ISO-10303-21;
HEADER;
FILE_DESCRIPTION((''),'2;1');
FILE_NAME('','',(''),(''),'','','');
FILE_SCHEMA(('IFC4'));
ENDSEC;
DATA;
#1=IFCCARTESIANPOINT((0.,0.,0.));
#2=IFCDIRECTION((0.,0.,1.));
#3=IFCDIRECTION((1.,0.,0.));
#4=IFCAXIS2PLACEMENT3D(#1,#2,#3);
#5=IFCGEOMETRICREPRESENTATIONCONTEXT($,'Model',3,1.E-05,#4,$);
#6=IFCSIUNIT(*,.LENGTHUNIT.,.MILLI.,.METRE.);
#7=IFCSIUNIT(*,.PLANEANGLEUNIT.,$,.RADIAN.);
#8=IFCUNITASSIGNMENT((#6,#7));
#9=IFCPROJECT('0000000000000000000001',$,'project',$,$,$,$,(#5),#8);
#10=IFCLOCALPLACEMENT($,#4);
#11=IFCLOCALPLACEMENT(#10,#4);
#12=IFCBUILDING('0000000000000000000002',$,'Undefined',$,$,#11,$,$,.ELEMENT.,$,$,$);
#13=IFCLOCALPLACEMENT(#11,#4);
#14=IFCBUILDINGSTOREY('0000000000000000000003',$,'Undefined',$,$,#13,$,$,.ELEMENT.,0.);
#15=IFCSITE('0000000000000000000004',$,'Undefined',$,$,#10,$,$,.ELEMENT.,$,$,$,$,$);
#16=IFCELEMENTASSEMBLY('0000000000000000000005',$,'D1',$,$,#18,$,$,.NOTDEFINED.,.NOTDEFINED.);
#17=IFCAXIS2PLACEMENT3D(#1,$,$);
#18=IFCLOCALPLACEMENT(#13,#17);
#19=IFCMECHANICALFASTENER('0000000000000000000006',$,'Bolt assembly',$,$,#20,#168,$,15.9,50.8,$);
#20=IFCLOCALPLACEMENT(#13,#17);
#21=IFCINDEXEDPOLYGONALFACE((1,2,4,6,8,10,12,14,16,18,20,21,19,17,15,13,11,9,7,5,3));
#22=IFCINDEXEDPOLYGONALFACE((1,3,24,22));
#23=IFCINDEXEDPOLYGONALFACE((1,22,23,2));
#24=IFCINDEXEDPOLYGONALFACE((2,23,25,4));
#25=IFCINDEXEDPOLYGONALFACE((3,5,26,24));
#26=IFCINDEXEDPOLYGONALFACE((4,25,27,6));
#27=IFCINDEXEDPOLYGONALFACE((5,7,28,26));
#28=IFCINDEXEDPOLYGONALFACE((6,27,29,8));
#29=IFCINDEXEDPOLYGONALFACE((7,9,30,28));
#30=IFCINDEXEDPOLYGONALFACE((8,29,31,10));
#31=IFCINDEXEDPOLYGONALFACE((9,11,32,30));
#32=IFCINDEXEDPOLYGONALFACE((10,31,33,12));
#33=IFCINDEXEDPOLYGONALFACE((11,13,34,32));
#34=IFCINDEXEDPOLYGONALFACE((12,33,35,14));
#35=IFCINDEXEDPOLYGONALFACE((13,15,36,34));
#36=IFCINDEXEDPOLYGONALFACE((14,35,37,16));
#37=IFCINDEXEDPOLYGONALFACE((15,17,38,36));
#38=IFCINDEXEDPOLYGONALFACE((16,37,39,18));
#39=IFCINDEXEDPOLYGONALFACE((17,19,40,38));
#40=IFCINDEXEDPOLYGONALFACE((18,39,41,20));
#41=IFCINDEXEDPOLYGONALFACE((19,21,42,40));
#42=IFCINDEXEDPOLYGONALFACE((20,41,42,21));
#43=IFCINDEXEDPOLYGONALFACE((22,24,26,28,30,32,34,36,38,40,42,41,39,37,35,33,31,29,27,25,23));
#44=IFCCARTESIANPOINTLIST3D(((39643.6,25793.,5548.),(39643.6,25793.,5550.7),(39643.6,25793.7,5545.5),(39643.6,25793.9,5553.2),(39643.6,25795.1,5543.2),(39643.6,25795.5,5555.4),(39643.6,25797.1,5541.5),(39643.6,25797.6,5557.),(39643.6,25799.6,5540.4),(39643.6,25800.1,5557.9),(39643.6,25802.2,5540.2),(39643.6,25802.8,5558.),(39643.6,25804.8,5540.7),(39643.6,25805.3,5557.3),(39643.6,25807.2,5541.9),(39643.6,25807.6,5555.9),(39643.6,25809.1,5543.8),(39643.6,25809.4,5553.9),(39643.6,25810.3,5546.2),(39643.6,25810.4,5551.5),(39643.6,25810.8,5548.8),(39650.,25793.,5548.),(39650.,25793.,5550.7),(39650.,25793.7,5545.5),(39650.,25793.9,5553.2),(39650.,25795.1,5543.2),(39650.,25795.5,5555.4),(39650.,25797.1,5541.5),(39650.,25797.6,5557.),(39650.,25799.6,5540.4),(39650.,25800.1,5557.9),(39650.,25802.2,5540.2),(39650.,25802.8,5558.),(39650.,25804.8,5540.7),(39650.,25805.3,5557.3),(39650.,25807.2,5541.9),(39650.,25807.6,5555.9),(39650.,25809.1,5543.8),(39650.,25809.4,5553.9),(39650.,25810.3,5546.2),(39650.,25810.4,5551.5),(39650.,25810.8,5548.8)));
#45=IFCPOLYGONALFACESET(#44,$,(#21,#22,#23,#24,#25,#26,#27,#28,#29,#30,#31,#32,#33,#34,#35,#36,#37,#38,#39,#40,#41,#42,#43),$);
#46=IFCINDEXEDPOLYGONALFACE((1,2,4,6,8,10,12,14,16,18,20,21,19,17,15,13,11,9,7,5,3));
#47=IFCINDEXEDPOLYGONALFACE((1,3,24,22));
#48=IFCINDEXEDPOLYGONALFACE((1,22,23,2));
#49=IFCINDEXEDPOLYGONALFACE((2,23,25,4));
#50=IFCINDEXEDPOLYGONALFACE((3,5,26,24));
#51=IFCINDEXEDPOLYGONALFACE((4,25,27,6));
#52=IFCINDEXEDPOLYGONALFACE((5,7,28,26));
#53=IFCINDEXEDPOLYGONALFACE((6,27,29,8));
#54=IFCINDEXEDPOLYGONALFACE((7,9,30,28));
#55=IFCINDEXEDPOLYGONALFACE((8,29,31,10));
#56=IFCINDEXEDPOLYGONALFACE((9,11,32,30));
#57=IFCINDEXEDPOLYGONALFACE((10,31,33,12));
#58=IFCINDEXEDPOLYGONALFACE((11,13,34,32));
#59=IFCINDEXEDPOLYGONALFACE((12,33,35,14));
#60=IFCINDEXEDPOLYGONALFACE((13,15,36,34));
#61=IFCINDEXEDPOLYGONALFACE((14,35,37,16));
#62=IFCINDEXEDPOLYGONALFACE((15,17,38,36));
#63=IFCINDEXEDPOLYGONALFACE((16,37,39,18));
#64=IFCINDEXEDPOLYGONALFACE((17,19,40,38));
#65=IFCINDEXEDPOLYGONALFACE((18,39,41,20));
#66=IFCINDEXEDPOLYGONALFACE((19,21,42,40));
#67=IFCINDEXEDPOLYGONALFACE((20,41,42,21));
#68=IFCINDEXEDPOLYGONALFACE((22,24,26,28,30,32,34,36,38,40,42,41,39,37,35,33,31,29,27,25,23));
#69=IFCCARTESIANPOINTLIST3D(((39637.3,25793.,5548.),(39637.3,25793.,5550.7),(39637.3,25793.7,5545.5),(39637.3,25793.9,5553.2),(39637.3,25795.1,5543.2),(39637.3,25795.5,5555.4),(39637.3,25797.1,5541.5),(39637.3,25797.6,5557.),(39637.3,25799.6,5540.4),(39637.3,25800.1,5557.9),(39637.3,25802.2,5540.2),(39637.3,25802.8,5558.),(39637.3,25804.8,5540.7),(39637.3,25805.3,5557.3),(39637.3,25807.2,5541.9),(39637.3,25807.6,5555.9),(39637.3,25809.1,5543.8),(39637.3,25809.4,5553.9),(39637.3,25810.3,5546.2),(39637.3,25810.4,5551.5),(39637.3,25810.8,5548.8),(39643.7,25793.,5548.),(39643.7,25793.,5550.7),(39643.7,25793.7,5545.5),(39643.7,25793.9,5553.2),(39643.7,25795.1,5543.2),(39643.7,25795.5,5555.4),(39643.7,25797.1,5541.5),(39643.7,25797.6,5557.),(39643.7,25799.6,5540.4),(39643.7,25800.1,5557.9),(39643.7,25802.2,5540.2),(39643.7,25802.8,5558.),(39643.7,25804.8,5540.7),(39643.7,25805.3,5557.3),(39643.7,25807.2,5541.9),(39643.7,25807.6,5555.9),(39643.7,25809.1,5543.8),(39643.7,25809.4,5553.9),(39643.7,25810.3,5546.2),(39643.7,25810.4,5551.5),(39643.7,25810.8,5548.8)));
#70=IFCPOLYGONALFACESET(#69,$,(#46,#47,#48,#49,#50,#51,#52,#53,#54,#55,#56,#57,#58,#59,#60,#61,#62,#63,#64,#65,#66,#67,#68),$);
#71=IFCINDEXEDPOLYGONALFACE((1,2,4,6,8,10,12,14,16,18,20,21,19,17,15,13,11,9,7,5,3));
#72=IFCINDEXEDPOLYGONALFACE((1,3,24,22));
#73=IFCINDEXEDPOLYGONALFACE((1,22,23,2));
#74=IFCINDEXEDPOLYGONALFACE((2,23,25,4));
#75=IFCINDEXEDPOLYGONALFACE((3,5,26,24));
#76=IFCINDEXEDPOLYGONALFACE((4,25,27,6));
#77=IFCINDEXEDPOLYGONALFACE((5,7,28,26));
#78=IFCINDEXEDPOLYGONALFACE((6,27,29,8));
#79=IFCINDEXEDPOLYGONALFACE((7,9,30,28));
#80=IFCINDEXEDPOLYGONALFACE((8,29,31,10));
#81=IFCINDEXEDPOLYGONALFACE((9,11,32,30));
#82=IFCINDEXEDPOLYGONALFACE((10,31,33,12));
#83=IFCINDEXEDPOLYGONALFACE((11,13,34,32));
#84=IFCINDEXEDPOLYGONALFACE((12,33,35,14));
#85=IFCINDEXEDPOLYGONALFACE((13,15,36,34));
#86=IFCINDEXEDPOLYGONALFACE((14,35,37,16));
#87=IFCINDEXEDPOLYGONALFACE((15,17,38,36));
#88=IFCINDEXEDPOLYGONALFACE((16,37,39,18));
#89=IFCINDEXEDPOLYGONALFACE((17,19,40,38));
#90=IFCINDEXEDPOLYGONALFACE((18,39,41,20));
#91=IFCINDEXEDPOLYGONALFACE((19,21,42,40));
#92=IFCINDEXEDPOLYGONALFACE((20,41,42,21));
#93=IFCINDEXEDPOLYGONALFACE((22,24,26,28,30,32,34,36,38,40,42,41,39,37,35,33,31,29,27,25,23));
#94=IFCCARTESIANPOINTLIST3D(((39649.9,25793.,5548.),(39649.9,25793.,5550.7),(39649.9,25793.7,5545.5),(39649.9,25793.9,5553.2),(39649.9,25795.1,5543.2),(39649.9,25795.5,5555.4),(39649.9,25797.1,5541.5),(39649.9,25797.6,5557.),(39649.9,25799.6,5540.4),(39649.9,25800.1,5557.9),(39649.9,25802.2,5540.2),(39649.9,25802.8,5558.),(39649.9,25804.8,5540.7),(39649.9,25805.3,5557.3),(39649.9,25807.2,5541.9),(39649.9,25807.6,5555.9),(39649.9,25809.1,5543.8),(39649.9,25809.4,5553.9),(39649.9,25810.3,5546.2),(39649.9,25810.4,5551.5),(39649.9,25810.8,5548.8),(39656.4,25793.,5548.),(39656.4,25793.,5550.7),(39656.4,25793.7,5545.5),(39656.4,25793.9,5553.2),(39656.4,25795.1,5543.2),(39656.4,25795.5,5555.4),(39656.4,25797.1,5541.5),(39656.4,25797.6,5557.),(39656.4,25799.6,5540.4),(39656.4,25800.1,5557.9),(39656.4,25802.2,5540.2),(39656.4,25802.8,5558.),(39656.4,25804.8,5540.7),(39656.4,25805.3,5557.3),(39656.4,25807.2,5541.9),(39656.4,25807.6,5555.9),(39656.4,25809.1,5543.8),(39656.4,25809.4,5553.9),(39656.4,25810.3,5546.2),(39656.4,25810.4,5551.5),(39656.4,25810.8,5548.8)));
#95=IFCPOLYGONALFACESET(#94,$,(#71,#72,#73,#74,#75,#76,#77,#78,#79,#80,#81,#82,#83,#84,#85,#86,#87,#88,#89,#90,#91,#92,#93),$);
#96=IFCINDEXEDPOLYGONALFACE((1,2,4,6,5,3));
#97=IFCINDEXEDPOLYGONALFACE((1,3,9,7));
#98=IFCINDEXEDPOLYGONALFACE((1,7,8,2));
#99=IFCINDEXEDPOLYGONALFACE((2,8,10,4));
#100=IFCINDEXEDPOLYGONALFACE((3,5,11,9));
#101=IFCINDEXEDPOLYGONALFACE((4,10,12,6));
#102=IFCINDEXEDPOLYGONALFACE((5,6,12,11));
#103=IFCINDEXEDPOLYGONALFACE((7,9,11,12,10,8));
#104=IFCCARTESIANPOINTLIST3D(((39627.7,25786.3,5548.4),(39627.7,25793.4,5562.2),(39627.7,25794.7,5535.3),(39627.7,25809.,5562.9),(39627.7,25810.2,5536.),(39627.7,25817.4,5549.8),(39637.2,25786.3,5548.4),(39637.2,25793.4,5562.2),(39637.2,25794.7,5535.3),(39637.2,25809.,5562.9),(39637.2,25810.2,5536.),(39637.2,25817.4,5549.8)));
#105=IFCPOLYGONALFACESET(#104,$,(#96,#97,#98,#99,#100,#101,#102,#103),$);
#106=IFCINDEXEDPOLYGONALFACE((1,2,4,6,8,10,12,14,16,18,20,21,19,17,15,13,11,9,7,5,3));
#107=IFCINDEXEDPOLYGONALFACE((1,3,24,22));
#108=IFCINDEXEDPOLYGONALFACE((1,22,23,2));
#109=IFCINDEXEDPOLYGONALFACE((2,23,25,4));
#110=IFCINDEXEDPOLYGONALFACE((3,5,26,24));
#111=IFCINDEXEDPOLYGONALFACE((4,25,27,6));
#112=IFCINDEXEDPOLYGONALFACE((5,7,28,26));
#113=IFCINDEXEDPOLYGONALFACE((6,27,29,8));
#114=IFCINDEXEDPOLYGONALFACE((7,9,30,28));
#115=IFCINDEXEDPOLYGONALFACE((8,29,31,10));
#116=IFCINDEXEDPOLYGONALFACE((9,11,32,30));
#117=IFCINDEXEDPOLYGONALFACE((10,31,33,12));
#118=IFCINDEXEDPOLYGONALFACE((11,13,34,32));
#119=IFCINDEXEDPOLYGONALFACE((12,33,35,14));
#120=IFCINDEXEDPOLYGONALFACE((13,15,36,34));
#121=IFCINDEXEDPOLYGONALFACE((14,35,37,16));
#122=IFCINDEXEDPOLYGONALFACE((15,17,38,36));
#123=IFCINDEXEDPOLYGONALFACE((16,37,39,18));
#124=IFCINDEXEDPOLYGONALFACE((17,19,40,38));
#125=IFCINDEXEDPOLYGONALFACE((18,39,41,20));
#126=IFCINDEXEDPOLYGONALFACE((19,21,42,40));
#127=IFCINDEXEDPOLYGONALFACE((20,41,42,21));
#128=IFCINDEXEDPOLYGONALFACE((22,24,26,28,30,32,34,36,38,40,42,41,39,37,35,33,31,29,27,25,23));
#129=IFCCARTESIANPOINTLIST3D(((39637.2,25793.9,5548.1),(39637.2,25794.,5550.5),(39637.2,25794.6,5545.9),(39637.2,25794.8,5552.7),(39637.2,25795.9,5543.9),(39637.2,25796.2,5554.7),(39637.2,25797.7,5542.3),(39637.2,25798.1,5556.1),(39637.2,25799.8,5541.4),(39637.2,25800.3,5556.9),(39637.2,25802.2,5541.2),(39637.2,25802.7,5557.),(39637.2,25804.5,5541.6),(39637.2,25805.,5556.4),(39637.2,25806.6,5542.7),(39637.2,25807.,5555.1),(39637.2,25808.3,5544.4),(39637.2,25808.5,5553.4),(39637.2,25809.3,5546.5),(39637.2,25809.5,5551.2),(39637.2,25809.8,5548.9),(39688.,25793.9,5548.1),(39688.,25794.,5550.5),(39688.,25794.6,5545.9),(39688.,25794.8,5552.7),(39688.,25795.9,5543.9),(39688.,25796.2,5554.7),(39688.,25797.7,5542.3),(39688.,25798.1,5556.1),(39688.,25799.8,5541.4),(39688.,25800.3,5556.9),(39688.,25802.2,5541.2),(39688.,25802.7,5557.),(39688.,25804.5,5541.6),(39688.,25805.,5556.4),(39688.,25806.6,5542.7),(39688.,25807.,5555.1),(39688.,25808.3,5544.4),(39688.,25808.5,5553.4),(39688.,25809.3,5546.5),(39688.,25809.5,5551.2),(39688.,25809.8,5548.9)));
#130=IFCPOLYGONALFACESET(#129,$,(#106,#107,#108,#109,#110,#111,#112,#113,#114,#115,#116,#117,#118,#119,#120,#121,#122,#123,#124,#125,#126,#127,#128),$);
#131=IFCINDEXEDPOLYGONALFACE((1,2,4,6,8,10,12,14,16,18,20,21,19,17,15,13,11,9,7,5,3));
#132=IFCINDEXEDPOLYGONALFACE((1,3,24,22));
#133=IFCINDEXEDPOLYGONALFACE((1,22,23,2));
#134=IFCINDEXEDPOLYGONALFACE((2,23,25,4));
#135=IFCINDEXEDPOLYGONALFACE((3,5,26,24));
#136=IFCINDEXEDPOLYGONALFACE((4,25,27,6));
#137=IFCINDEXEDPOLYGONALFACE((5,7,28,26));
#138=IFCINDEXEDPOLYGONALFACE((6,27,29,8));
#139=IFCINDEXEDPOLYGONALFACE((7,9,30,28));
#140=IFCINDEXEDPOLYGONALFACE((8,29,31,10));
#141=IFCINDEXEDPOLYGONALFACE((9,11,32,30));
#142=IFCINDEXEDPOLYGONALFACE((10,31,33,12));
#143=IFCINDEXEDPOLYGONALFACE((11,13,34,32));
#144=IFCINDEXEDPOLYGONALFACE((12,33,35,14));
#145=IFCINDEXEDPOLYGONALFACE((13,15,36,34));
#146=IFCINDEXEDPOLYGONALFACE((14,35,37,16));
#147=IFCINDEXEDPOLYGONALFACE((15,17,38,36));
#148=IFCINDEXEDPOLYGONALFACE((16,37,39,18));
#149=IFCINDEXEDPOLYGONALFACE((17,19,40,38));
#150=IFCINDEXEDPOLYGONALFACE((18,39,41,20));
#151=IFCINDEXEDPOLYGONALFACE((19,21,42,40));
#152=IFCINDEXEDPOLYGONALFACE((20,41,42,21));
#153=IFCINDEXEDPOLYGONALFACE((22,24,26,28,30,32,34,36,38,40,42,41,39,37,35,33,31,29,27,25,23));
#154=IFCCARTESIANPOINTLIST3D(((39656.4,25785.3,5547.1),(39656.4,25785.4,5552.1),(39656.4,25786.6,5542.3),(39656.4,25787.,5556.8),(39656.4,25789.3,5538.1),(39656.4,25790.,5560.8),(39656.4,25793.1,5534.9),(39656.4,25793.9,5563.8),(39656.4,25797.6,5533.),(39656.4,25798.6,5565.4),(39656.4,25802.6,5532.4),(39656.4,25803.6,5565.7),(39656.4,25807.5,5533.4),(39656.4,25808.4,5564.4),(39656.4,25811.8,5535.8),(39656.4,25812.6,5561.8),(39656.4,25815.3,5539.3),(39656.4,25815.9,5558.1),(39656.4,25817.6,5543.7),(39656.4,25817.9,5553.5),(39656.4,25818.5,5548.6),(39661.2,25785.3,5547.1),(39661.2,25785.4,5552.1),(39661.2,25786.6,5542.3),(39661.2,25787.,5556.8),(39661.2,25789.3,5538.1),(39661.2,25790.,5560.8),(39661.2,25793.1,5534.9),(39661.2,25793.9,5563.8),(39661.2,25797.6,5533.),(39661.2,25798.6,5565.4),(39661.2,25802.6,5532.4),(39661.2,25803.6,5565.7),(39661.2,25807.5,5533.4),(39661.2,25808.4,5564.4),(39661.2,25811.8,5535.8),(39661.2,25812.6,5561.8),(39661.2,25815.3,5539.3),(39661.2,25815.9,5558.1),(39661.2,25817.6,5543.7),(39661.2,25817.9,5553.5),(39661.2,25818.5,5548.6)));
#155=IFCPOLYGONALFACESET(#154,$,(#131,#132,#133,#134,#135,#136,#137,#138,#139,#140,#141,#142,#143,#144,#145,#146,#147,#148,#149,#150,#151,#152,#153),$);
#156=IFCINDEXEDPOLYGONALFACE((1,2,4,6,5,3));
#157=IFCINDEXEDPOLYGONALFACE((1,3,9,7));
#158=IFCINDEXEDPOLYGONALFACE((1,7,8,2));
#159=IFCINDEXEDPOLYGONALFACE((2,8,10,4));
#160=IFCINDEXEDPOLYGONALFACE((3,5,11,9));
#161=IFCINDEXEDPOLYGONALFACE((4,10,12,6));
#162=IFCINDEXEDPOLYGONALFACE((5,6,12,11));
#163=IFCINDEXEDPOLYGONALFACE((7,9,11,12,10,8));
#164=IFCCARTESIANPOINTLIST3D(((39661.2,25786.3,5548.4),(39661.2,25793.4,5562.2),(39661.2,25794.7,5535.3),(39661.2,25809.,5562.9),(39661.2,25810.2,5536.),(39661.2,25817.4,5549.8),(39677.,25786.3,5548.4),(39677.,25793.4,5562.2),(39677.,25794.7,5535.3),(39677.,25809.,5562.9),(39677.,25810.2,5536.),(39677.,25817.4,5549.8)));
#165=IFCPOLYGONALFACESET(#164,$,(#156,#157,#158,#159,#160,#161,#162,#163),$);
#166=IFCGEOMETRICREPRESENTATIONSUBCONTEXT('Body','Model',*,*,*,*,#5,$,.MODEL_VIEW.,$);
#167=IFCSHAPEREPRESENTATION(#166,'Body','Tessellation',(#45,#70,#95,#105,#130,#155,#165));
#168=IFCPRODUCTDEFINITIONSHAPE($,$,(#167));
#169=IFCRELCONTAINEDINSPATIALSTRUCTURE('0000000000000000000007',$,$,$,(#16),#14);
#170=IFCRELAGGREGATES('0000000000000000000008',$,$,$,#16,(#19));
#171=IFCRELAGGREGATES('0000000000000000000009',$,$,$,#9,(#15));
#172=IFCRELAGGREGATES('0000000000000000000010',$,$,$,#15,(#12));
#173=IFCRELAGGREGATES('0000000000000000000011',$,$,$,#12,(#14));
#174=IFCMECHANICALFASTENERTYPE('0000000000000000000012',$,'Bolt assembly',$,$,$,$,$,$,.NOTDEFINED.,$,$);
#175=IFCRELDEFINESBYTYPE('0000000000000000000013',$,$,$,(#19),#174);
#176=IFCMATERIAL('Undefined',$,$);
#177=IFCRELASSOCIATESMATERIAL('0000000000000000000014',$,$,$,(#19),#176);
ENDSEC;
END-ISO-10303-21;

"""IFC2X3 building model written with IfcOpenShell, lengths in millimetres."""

from ifc_helpers import new_model, si_unit, frame, origin_with_axes, origin_2d_with_axis, place, context, subcontext, project, spatial, polyline, circle, outline, extrude, source, transform, mapped, material, type_object, element, aggregate, save


model = new_model("IFC2X3")

# Units and contexts
model_context = context("Model", 3, precision=1e-05, world=origin_with_axes())
body_context = subcontext(model_context, "Body", "Model", "MODEL_VIEW")
ifc_project = project(units=[si_unit("LENGTHUNIT", "METRE", prefix="MILLI"), si_unit("PLANEANGLEUNIT", "RADIAN")], contexts=[model_context])

# Site, building, storey
site_placement = place(None, origin_with_axes())
site = spatial("IfcSite", under=ifc_project, at=site_placement, Name="Undefined", CompositionType="ELEMENT")
building_placement = place(site_placement, origin_with_axes())
building = spatial("IfcBuilding", under=site, at=building_placement, Name="Undefined", CompositionType="ELEMENT")
storey_placement = place(building_placement, origin_with_axes())
storey = spatial("IfcBuildingStorey", under=building, at=storey_placement, Name="Undefined", CompositionType="ELEMENT", Elevation=0.0)

# Shared definitions
ifc_material_1 = material(Name="Undefined")
mechanical_fastener_type = type_object("IfcMechanicalFastenerType", Name="Bolt assembly")

# Element assembly, mechanical fastener
assembly_1_placement = place(storey_placement, origin_with_axes())
assembly_1 = element("IfcElementAssembly", 1, at=assembly_1_placement, inside=storey, Name="D1", AssemblyPlace="NOTDEFINED", PredefinedType="NOTDEFINED")
shared_shape_1 = source(origin_with_axes(), body_context, "Body", "SweptSolid", [
    extrude(circle(Radius=8.9, at=origin_2d_with_axis()), frame((0.0, -3.2, 0.0), z_axis=(0.0, 1.0, 0.0), x_axis=(1.0, 0.0, 0.0)), (0.0, 0.0, 1.0), 6.4),
    extrude(circle(Radius=8.9, at=origin_2d_with_axis()), frame((0.0, -9.5, 0.0), z_axis=(0.0, 1.0, 0.0), x_axis=(1.0, 0.0, 0.0)), (0.0, 0.0, 1.0), 6.4),
    extrude(circle(Radius=8.9, at=origin_2d_with_axis()), frame((0.0, 3.1, 0.0), z_axis=(0.0, 1.0, 0.0), x_axis=(1.0, 0.0, 0.0)), (0.0, 0.0, 1.0), 6.5),
    extrude(outline(polyline([(13.5, -7.8), (13.5, 7.8), (0.0, 15.6), (-13.5, 7.8), (-13.5, -7.8), (0.0, -15.6), (13.5, -7.8)])), frame((0.0, -19.1, 0.0), z_axis=(0.0, 1.0, 0.0), x_axis=(1.0, 0.0, 0.0)), (0.0, 0.0, 1.0), 9.5),
    extrude(circle(Radius=7.9, at=origin_2d_with_axis()), frame((0.0, -9.6, 0.0), z_axis=(0.0, 1.0, 0.0), x_axis=(1.0, 0.0, 0.0)), (0.0, 0.0, 1.0), 50.8),
    extrude(circle(Radius=16.7, at=origin_2d_with_axis()), frame((0.0, 9.6, 0.0), z_axis=(0.0, 1.0, 0.0), x_axis=(1.0, 0.0, 0.0)), (0.0, 0.0, 1.0), 4.8),
    extrude(outline(polyline([(13.5, -7.8), (13.5, 7.8), (0.0, 15.6), (-13.5, 7.8), (-13.5, -7.8), (0.0, -15.6), (13.5, -7.8)])), frame((0.0, 14.4, 0.0), z_axis=(0.0, 1.0, 0.0), x_axis=(1.0, 0.0, 0.0)), (0.0, 0.0, 1.0), 15.9),
])
mechanical_fastener_1_placement = place(assembly_1_placement, frame((39646.8, 25801.8, 5549.1), z_axis=(0.0, 0.460509, 0.887655), x_axis=(0.0, -0.887655, 0.460509)))
mechanical_fastener_1 = element("IfcMechanicalFastener", 2, at=mechanical_fastener_1_placement, type_object=mechanical_fastener_type, material=ifc_material_1, Name="Bolt assembly", NominalDiameter=15.9, NominalLength=50.8, context=body_context, shape_type="MappedRepresentation", body=[
    mapped(shared_shape_1, transform((0.0, 0.0, 0.0))),
])

aggregate(assembly_1, [mechanical_fastener_1])

save(model, "model.ifc")
